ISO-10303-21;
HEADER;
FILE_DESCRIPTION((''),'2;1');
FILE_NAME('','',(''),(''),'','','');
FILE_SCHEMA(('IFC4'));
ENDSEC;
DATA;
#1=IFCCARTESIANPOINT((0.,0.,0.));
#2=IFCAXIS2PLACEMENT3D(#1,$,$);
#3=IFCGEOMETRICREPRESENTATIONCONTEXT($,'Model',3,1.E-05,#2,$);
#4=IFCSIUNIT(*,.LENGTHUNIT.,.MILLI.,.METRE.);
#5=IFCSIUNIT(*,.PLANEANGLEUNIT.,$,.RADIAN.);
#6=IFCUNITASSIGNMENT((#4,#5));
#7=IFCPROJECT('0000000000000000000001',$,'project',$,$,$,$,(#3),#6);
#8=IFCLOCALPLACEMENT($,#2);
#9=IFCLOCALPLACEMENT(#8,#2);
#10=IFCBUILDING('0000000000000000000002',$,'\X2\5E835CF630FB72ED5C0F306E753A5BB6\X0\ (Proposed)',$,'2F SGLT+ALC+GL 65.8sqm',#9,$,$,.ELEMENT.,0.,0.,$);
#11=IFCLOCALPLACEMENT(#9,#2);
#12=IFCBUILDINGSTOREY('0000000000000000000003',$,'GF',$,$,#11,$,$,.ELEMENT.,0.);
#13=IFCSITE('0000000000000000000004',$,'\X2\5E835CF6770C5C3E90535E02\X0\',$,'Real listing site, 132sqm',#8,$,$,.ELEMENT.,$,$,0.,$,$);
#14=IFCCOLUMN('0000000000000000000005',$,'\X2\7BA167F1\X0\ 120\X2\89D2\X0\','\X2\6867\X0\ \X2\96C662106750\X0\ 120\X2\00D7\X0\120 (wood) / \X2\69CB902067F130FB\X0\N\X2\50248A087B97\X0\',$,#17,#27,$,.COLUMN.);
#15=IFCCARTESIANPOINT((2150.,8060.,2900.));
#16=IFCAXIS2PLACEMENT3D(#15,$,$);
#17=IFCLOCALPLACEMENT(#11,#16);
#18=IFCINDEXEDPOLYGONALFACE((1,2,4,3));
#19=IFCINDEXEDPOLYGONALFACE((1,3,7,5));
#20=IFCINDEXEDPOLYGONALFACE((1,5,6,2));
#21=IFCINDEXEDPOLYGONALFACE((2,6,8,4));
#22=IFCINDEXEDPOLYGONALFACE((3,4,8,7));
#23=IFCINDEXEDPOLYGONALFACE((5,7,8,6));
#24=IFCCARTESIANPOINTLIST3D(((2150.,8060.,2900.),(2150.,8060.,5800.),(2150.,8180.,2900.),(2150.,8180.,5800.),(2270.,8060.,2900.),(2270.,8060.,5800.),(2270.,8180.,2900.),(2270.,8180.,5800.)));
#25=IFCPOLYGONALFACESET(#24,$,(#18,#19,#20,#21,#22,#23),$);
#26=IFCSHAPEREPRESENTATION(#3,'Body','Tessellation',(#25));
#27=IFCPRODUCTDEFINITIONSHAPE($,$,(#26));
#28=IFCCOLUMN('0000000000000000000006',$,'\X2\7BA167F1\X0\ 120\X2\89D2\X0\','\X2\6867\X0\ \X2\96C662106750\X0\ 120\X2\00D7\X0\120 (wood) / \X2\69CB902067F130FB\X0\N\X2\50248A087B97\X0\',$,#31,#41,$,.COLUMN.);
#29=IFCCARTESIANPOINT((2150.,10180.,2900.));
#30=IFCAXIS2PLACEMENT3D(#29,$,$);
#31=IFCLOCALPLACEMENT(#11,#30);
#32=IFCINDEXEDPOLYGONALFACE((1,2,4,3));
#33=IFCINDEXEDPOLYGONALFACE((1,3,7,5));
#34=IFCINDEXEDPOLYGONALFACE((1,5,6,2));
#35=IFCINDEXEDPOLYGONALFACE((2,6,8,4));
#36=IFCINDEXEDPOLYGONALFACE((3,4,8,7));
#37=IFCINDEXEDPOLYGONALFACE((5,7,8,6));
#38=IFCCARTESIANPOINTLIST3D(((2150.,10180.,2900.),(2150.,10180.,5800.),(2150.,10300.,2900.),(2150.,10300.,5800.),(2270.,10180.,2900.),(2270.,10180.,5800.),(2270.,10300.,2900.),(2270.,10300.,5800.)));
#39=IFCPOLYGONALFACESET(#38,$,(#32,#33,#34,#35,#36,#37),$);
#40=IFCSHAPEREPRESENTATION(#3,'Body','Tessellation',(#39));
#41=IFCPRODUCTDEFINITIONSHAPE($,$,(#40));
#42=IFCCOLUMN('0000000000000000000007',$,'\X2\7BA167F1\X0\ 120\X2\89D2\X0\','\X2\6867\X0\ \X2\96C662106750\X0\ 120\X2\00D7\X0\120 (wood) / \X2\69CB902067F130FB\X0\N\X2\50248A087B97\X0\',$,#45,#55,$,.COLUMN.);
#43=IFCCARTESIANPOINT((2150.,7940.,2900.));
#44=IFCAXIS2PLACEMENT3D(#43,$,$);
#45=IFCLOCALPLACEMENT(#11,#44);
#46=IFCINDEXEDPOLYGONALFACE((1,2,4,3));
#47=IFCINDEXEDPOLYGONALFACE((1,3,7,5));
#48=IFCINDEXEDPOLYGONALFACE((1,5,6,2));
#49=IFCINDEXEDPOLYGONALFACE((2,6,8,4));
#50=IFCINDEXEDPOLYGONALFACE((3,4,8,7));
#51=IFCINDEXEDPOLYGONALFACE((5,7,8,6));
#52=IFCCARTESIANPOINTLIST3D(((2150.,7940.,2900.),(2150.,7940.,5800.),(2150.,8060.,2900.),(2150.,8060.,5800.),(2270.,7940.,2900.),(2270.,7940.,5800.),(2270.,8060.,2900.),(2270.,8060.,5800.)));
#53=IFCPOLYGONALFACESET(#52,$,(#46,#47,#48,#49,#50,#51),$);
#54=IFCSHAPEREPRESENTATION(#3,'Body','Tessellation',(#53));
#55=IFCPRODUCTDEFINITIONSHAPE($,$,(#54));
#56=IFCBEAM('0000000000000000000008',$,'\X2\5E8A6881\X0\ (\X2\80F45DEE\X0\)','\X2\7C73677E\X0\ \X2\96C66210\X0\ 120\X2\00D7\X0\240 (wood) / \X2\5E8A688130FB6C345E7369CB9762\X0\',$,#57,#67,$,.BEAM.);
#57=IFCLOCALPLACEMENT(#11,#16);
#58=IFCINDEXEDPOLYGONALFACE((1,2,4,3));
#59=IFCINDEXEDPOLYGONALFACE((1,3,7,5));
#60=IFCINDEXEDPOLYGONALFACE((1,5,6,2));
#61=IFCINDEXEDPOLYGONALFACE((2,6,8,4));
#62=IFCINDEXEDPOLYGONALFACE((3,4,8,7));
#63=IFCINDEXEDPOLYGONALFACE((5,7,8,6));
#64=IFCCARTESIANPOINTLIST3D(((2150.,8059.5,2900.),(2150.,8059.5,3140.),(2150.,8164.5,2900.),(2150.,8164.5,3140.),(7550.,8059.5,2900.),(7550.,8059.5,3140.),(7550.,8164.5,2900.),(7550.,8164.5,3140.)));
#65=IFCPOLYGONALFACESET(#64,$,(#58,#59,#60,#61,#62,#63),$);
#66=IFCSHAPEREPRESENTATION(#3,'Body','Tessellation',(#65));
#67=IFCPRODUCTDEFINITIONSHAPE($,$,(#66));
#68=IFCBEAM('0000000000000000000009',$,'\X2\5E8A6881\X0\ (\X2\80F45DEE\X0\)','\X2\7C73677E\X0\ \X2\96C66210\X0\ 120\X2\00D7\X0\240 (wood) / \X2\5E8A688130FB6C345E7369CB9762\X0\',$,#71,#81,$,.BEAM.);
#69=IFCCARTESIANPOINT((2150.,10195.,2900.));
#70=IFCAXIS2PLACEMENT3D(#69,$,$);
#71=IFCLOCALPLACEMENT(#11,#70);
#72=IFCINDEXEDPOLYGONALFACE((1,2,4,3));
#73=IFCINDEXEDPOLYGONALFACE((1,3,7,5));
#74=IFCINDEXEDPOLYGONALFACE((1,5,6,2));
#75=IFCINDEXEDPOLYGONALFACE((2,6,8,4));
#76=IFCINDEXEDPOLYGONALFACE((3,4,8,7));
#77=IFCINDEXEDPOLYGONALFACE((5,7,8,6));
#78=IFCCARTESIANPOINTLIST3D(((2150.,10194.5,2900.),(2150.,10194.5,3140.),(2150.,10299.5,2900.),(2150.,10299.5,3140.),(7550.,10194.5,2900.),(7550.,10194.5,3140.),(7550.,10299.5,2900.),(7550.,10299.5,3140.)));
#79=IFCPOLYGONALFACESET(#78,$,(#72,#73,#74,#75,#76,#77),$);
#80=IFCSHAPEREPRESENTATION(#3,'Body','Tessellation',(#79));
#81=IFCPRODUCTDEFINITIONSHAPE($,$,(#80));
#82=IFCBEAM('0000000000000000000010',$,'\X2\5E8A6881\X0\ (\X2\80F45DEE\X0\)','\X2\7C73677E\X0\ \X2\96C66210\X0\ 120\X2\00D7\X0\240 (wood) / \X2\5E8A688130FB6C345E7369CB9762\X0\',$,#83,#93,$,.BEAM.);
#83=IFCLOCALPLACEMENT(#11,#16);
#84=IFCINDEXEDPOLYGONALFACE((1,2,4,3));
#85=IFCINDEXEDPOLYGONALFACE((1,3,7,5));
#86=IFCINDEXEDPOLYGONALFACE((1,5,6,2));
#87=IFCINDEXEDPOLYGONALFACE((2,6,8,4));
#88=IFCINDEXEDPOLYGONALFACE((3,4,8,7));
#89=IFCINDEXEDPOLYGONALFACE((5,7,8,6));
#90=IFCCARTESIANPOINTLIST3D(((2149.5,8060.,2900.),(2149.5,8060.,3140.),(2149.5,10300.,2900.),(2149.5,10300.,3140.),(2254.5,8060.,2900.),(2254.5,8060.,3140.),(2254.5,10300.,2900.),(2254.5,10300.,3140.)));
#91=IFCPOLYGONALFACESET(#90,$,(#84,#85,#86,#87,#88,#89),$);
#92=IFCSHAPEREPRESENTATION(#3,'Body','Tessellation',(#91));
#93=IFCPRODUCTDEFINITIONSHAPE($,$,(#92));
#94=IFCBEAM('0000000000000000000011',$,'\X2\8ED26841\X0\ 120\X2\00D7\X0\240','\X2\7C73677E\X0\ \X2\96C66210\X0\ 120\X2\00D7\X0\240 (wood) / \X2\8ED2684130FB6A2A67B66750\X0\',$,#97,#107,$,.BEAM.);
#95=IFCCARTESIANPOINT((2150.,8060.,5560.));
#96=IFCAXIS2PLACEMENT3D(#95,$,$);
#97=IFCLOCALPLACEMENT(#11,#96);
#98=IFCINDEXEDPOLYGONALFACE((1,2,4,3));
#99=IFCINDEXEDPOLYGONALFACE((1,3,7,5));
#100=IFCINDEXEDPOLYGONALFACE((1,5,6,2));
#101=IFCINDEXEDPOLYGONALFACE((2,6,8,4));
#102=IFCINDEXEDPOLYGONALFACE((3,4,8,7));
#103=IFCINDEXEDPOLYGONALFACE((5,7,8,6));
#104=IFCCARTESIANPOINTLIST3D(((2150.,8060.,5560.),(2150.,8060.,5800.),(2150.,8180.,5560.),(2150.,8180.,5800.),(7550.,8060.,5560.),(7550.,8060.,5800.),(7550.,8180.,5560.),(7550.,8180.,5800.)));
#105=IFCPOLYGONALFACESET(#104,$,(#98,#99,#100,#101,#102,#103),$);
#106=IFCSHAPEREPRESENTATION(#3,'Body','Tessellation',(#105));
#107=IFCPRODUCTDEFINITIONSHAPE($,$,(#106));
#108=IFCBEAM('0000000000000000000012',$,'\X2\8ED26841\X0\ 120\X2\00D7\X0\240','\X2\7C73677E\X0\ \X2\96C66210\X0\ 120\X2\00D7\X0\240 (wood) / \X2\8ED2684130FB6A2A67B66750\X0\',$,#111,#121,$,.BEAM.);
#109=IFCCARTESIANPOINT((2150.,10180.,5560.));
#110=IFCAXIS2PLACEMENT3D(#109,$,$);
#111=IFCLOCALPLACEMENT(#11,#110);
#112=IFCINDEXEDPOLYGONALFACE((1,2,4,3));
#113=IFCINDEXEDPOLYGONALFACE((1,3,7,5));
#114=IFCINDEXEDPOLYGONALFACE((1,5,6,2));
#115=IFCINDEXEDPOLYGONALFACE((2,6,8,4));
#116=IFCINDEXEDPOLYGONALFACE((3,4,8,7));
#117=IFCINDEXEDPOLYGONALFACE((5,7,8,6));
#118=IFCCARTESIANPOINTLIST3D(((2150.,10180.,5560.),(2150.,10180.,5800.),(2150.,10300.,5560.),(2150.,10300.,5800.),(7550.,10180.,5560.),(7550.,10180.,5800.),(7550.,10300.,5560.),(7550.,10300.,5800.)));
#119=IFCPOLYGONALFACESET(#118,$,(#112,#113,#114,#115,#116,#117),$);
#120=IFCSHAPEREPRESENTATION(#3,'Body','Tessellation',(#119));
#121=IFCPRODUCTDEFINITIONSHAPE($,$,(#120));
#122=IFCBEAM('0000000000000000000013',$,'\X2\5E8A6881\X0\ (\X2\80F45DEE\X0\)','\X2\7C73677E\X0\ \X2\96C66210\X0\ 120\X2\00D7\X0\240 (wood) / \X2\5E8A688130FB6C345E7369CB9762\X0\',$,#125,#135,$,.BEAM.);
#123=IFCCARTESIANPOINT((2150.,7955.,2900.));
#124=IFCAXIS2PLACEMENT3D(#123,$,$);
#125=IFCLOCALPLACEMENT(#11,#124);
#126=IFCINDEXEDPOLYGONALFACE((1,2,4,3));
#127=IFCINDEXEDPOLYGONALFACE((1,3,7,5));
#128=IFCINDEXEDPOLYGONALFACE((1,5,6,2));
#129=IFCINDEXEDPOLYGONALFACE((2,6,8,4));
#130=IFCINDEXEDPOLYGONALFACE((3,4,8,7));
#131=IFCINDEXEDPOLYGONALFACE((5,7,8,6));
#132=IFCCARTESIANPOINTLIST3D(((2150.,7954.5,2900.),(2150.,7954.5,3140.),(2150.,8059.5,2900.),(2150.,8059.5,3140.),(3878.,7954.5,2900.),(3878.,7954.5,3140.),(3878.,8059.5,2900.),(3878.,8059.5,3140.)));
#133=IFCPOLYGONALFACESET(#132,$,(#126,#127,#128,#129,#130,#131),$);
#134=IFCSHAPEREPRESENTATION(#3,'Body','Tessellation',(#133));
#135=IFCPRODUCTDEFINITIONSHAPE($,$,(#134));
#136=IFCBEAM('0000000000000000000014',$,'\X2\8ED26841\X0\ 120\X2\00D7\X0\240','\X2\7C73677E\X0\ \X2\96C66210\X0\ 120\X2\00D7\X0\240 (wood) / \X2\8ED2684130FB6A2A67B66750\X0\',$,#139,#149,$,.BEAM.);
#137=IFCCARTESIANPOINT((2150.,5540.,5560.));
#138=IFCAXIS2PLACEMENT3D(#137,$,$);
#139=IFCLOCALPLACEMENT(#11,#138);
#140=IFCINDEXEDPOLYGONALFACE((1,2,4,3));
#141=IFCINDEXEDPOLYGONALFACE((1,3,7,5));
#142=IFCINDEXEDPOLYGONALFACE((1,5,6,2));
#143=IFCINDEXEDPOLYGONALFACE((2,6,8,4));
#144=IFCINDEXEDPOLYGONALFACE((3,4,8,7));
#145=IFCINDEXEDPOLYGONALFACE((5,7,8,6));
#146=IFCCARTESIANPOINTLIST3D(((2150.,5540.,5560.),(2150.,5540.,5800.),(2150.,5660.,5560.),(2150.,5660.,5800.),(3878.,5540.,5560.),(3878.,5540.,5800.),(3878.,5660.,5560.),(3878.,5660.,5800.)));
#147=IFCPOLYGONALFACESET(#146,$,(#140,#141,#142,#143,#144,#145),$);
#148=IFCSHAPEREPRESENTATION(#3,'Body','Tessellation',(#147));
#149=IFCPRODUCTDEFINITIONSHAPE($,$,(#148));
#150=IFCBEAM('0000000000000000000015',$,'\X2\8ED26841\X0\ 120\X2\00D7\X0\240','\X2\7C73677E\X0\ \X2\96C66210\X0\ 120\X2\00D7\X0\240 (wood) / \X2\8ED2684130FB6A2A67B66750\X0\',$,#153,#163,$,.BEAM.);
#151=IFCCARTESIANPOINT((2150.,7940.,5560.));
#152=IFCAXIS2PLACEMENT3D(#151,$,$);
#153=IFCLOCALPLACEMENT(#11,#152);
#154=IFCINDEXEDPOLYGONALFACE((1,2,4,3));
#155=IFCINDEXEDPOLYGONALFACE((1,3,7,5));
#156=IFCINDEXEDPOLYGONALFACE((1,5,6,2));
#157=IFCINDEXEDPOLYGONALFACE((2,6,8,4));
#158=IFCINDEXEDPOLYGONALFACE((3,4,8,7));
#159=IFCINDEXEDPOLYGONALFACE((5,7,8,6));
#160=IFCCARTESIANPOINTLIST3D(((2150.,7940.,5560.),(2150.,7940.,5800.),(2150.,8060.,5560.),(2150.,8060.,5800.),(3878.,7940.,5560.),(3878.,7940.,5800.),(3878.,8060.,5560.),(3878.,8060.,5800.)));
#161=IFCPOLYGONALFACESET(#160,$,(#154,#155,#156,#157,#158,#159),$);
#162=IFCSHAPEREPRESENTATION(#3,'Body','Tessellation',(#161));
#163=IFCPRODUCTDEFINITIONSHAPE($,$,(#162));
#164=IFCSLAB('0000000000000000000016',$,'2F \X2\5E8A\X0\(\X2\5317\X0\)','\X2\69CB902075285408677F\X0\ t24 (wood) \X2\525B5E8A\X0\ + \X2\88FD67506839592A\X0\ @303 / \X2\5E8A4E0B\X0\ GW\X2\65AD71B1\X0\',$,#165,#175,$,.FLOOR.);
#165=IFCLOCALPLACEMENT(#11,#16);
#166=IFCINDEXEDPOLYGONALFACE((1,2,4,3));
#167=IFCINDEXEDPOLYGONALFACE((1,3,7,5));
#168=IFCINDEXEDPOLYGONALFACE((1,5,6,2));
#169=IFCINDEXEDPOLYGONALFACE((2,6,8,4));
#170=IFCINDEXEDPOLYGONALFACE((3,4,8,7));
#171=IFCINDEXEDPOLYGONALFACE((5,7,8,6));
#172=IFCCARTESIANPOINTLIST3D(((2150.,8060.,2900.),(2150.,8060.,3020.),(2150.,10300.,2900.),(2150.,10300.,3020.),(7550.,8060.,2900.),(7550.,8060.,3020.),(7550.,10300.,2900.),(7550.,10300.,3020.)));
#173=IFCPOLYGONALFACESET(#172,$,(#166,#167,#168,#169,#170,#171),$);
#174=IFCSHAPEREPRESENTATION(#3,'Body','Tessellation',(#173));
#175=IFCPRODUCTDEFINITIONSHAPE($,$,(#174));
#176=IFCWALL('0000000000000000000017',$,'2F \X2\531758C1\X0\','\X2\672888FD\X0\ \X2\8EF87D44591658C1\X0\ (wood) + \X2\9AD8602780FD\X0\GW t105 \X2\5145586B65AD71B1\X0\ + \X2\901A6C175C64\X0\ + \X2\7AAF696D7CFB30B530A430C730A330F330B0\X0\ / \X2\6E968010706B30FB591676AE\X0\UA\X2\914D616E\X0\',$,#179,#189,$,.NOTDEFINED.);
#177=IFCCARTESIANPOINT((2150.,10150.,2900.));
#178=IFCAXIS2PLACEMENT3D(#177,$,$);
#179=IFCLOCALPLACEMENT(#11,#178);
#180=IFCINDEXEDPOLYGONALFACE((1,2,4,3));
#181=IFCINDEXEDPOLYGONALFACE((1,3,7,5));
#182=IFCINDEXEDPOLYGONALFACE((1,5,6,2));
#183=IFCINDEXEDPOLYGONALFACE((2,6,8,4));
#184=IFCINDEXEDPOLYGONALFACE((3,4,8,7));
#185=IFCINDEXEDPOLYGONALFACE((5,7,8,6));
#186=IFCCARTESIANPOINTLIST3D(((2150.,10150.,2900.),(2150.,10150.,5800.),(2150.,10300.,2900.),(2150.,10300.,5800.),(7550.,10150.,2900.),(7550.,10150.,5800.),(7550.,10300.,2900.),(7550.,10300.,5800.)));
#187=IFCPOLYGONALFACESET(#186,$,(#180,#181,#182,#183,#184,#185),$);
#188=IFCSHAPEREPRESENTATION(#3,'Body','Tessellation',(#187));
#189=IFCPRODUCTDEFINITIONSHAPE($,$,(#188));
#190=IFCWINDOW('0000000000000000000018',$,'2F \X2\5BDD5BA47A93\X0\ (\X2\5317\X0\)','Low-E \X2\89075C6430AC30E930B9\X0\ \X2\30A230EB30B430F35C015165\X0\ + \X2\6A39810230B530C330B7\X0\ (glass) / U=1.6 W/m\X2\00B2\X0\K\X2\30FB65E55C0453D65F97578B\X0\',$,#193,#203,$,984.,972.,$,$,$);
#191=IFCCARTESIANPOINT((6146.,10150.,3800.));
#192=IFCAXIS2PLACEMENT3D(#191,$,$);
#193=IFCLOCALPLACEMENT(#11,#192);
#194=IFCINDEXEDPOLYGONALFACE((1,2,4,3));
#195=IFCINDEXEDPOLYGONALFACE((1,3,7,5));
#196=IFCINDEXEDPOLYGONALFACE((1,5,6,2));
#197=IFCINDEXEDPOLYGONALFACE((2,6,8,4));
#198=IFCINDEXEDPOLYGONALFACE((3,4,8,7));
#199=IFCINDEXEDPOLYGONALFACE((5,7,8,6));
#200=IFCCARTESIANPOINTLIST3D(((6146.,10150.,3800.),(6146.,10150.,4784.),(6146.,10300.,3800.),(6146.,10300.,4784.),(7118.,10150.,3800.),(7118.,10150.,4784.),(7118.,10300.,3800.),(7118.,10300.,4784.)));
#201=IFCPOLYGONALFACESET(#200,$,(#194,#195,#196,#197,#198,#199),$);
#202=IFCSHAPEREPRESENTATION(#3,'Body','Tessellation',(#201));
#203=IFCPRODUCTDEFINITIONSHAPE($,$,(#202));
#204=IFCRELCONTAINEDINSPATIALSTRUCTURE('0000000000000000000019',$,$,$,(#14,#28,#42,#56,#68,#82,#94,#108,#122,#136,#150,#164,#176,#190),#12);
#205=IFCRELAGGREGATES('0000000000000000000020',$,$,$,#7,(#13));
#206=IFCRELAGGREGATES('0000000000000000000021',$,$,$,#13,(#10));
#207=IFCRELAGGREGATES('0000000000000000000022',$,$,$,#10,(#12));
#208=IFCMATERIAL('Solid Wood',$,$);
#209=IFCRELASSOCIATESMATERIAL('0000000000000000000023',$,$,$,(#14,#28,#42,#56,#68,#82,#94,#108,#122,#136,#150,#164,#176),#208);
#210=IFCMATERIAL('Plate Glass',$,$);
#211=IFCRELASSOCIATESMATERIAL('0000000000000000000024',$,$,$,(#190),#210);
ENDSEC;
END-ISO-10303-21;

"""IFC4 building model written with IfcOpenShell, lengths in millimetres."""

from ifc_helpers import new_model, si_unit, frame, frame_2d, origin, place, context, project, spatial, rectangle, extrude, material, element, fill, save


model = new_model("IFC4")

# Units and contexts
model_context = context("Model", 3, precision=1e-05, world=origin())
ifc_project = project(units=[si_unit("LENGTHUNIT", "METRE", prefix="MILLI"), si_unit("PLANEANGLEUNIT", "RADIAN")], contexts=[model_context])

# Site, building, storey
site_placement = place(None, origin())
site = spatial("IfcSite", under=ifc_project, at=site_placement, Name="広島県尾道市", ObjectType="Real listing site, 132sqm", CompositionType="ELEMENT", RefElevation=0.0)
building_placement = place(site_placement, origin())
building = spatial("IfcBuilding", under=site, at=building_placement, Name="広島・狭小の町家 (Proposed)", ObjectType="2F SGLT+ALC+GL 65.8sqm", CompositionType="ELEMENT", ElevationOfRefHeight=0.0, ElevationOfTerrain=0.0)
storey_placement = place(building_placement, origin())
storey = spatial("IfcBuildingStorey", under=building, at=storey_placement, Name="GF", CompositionType="ELEMENT", Elevation=0.0)

# Columns
ifc_material_1 = material(Name="Solid Wood")
column_1_placement = place(storey_placement, frame((2150.0, 8060.0, 2900.0)))
element("IfcColumn", 1, at=column_1_placement, inside=storey, material=ifc_material_1, Name="管柱 120角", Description="桧 集成材 120×120 (wood) / 構造柱・N値計算", PredefinedType="COLUMN", context=model_context, shape_type="SweptSolid", body=[
    extrude(rectangle(XDim=120.0, YDim=120.0, at=frame_2d((60.0, 60.0))), frame((2150.0, 8060.0, 2900.0)), (0.0, 0.0, 1.0), 2900.0),
])
column_2_placement = place(storey_placement, frame((2150.0, 10180.0, 2900.0)))
element("IfcColumn", 2, at=column_2_placement, inside=storey, material=ifc_material_1, Name="管柱 120角", Description="桧 集成材 120×120 (wood) / 構造柱・N値計算", PredefinedType="COLUMN", context=model_context, shape_type="SweptSolid", body=[
    extrude(rectangle(XDim=120.0, YDim=120.0, at=frame_2d((60.0, 60.0))), frame((2150.0, 10180.0, 2900.0)), (0.0, 0.0, 1.0), 2900.0),
])
column_3_placement = place(storey_placement, frame((2150.0, 7940.0, 2900.0)))
element("IfcColumn", 3, at=column_3_placement, inside=storey, material=ifc_material_1, Name="管柱 120角", Description="桧 集成材 120×120 (wood) / 構造柱・N値計算", PredefinedType="COLUMN", context=model_context, shape_type="SweptSolid", body=[
    extrude(rectangle(XDim=120.0, YDim=120.0, at=frame_2d((60.0, 60.0))), frame((2150.0, 7940.0, 2900.0)), (0.0, 0.0, 1.0), 2900.0),
])

# Beams
beam_1_placement = place(storey_placement, frame((2150.0, 8060.0, 2900.0)))
element("IfcBeam", 4, at=beam_1_placement, inside=storey, material=ifc_material_1, Name="床梁 (胴差)", Description="米松 集成 120×240 (wood) / 床梁・水平構面", PredefinedType="BEAM", context=model_context, shape_type="SweptSolid", body=[
    extrude(rectangle(XDim=5400.0, YDim=105.0, at=frame_2d((2700.0, 52.0))), frame((2150.0, 8060.0, 2900.0)), (0.0, 0.0, 1.0), 240.0),
])
beam_2_placement = place(storey_placement, frame((2150.0, 10195.0, 2900.0)))
element("IfcBeam", 5, at=beam_2_placement, inside=storey, material=ifc_material_1, Name="床梁 (胴差)", Description="米松 集成 120×240 (wood) / 床梁・水平構面", PredefinedType="BEAM", context=model_context, shape_type="SweptSolid", body=[
    extrude(rectangle(XDim=5400.0, YDim=105.0, at=frame_2d((2700.0, 52.0))), frame((2150.0, 10195.0, 2900.0)), (0.0, 0.0, 1.0), 240.0),
])
beam_3_placement = place(storey_placement, frame((2150.0, 8060.0, 2900.0)))
element("IfcBeam", 6, at=beam_3_placement, inside=storey, material=ifc_material_1, Name="床梁 (胴差)", Description="米松 集成 120×240 (wood) / 床梁・水平構面", PredefinedType="BEAM", context=model_context, shape_type="SweptSolid", body=[
    extrude(rectangle(XDim=105.0, YDim=2240.0, at=frame_2d((52.0, 1120.0))), frame((2150.0, 8060.0, 2900.0)), (0.0, 0.0, 1.0), 240.0),
])
beam_4_placement = place(storey_placement, frame((2150.0, 8060.0, 5560.0)))
element("IfcBeam", 7, at=beam_4_placement, inside=storey, material=ifc_material_1, Name="軒桁 120×240", Description="米松 集成 120×240 (wood) / 軒桁・横架材", PredefinedType="BEAM", context=model_context, shape_type="SweptSolid", body=[
    extrude(rectangle(XDim=5400.0, YDim=120.0, at=frame_2d((2700.0, 60.0))), frame((2150.0, 8060.0, 5560.0)), (0.0, 0.0, 1.0), 240.0),
])
beam_5_placement = place(storey_placement, frame((2150.0, 10180.0, 5560.0)))
element("IfcBeam", 8, at=beam_5_placement, inside=storey, material=ifc_material_1, Name="軒桁 120×240", Description="米松 集成 120×240 (wood) / 軒桁・横架材", PredefinedType="BEAM", context=model_context, shape_type="SweptSolid", body=[
    extrude(rectangle(XDim=5400.0, YDim=120.0, at=frame_2d((2700.0, 60.0))), frame((2150.0, 10180.0, 5560.0)), (0.0, 0.0, 1.0), 240.0),
])
beam_6_placement = place(storey_placement, frame((2150.0, 7955.0, 2900.0)))
element("IfcBeam", 9, at=beam_6_placement, inside=storey, material=ifc_material_1, Name="床梁 (胴差)", Description="米松 集成 120×240 (wood) / 床梁・水平構面", PredefinedType="BEAM", context=model_context, shape_type="SweptSolid", body=[
    extrude(rectangle(XDim=1728.0, YDim=105.0, at=frame_2d((864.0, 52.0))), frame((2150.0, 7955.0, 2900.0)), (0.0, 0.0, 1.0), 240.0),
])
beam_7_placement = place(storey_placement, frame((2150.0, 5540.0, 5560.0)))
element("IfcBeam", 10, at=beam_7_placement, inside=storey, material=ifc_material_1, Name="軒桁 120×240", Description="米松 集成 120×240 (wood) / 軒桁・横架材", PredefinedType="BEAM", context=model_context, shape_type="SweptSolid", body=[
    extrude(rectangle(XDim=1728.0, YDim=120.0, at=frame_2d((864.0, 60.0))), frame((2150.0, 5540.0, 5560.0)), (0.0, 0.0, 1.0), 240.0),
])
beam_8_placement = place(storey_placement, frame((2150.0, 7940.0, 5560.0)))
element("IfcBeam", 11, at=beam_8_placement, inside=storey, material=ifc_material_1, Name="軒桁 120×240", Description="米松 集成 120×240 (wood) / 軒桁・横架材", PredefinedType="BEAM", context=model_context, shape_type="SweptSolid", body=[
    extrude(rectangle(XDim=1728.0, YDim=120.0, at=frame_2d((864.0, 60.0))), frame((2150.0, 7940.0, 5560.0)), (0.0, 0.0, 1.0), 240.0),
])

# Slab
slab_placement = place(storey_placement, frame((2150.0, 8060.0, 2900.0)))
element("IfcSlab", 12, at=slab_placement, inside=storey, material=ifc_material_1, Name="2F 床(北)", Description="構造用合板 t24 (wood) 剛床 + 製材根太 @303 / 床下 GW断熱", PredefinedType="FLOOR", context=model_context, shape_type="SweptSolid", body=[
    extrude(rectangle(XDim=5400.0, YDim=2240.0, at=frame_2d((2700.0, 1120.0))), frame((2150.0, 8060.0, 2900.0)), (0.0, 0.0, 1.0), 120.0),
])

# Wall, opening, window
wall_placement = place(storey_placement, frame((2150.0, 10150.0, 2900.0)))
wall = element("IfcWall", 13, at=wall_placement, inside=storey, material=ifc_material_1, Name="2F 北壁", Description="木製 軸組外壁 (wood) + 高性能GW t105 充填断熱 + 通気層 + 窯業系サイディング / 準耐火・外皮UA配慮", PredefinedType="NOTDEFINED", context=model_context, shape_type="SweptSolid", body=[
    extrude(rectangle(XDim=5400.0, YDim=150.0, at=frame_2d((2700.0, 75.0))), frame((2150.0, 10150.0, 2900.0)), (0.0, 0.0, 1.0), 2900.0),
])
opening_placement = place(storey_placement, frame((6146.0, 10150.0, 3800.0)))
opening = element("IfcOpeningElement", 14, at=opening_placement, cuts=wall, PredefinedType="NOTDEFINED", context=model_context, shape_type="SweptSolid", body=[
    extrude(rectangle(XDim=972.0, YDim=150.0, at=frame_2d((486.0, 75.0))), frame((6146.0, 10150.0, 3800.0)), (0.0, 0.0, 1.0), 984.0),
])
ifc_material_2 = material(Name="Plate Glass")
window_placement = place(storey_placement, frame((6146.0, 10150.0, 3800.0)))
window = element("IfcWindow", 15, at=window_placement, inside=storey, material=ifc_material_2, Name="2F 寝室窓 (北)", Description="Low-E 複層ガラス アルゴン封入 + 樹脂サッシ (glass) / U=1.6 W/m²K・日射取得型", OverallHeight=984.0, OverallWidth=972.0, context=model_context, shape_type="SweptSolid", body=[
    extrude(rectangle(XDim=972.0, YDim=150.0, at=frame_2d((486.0, 75.0))), frame((6146.0, 10150.0, 3800.0)), (0.0, 0.0, 1.0), 984.0),
])
fill(opening, window)

save(model, "model.ifc")
